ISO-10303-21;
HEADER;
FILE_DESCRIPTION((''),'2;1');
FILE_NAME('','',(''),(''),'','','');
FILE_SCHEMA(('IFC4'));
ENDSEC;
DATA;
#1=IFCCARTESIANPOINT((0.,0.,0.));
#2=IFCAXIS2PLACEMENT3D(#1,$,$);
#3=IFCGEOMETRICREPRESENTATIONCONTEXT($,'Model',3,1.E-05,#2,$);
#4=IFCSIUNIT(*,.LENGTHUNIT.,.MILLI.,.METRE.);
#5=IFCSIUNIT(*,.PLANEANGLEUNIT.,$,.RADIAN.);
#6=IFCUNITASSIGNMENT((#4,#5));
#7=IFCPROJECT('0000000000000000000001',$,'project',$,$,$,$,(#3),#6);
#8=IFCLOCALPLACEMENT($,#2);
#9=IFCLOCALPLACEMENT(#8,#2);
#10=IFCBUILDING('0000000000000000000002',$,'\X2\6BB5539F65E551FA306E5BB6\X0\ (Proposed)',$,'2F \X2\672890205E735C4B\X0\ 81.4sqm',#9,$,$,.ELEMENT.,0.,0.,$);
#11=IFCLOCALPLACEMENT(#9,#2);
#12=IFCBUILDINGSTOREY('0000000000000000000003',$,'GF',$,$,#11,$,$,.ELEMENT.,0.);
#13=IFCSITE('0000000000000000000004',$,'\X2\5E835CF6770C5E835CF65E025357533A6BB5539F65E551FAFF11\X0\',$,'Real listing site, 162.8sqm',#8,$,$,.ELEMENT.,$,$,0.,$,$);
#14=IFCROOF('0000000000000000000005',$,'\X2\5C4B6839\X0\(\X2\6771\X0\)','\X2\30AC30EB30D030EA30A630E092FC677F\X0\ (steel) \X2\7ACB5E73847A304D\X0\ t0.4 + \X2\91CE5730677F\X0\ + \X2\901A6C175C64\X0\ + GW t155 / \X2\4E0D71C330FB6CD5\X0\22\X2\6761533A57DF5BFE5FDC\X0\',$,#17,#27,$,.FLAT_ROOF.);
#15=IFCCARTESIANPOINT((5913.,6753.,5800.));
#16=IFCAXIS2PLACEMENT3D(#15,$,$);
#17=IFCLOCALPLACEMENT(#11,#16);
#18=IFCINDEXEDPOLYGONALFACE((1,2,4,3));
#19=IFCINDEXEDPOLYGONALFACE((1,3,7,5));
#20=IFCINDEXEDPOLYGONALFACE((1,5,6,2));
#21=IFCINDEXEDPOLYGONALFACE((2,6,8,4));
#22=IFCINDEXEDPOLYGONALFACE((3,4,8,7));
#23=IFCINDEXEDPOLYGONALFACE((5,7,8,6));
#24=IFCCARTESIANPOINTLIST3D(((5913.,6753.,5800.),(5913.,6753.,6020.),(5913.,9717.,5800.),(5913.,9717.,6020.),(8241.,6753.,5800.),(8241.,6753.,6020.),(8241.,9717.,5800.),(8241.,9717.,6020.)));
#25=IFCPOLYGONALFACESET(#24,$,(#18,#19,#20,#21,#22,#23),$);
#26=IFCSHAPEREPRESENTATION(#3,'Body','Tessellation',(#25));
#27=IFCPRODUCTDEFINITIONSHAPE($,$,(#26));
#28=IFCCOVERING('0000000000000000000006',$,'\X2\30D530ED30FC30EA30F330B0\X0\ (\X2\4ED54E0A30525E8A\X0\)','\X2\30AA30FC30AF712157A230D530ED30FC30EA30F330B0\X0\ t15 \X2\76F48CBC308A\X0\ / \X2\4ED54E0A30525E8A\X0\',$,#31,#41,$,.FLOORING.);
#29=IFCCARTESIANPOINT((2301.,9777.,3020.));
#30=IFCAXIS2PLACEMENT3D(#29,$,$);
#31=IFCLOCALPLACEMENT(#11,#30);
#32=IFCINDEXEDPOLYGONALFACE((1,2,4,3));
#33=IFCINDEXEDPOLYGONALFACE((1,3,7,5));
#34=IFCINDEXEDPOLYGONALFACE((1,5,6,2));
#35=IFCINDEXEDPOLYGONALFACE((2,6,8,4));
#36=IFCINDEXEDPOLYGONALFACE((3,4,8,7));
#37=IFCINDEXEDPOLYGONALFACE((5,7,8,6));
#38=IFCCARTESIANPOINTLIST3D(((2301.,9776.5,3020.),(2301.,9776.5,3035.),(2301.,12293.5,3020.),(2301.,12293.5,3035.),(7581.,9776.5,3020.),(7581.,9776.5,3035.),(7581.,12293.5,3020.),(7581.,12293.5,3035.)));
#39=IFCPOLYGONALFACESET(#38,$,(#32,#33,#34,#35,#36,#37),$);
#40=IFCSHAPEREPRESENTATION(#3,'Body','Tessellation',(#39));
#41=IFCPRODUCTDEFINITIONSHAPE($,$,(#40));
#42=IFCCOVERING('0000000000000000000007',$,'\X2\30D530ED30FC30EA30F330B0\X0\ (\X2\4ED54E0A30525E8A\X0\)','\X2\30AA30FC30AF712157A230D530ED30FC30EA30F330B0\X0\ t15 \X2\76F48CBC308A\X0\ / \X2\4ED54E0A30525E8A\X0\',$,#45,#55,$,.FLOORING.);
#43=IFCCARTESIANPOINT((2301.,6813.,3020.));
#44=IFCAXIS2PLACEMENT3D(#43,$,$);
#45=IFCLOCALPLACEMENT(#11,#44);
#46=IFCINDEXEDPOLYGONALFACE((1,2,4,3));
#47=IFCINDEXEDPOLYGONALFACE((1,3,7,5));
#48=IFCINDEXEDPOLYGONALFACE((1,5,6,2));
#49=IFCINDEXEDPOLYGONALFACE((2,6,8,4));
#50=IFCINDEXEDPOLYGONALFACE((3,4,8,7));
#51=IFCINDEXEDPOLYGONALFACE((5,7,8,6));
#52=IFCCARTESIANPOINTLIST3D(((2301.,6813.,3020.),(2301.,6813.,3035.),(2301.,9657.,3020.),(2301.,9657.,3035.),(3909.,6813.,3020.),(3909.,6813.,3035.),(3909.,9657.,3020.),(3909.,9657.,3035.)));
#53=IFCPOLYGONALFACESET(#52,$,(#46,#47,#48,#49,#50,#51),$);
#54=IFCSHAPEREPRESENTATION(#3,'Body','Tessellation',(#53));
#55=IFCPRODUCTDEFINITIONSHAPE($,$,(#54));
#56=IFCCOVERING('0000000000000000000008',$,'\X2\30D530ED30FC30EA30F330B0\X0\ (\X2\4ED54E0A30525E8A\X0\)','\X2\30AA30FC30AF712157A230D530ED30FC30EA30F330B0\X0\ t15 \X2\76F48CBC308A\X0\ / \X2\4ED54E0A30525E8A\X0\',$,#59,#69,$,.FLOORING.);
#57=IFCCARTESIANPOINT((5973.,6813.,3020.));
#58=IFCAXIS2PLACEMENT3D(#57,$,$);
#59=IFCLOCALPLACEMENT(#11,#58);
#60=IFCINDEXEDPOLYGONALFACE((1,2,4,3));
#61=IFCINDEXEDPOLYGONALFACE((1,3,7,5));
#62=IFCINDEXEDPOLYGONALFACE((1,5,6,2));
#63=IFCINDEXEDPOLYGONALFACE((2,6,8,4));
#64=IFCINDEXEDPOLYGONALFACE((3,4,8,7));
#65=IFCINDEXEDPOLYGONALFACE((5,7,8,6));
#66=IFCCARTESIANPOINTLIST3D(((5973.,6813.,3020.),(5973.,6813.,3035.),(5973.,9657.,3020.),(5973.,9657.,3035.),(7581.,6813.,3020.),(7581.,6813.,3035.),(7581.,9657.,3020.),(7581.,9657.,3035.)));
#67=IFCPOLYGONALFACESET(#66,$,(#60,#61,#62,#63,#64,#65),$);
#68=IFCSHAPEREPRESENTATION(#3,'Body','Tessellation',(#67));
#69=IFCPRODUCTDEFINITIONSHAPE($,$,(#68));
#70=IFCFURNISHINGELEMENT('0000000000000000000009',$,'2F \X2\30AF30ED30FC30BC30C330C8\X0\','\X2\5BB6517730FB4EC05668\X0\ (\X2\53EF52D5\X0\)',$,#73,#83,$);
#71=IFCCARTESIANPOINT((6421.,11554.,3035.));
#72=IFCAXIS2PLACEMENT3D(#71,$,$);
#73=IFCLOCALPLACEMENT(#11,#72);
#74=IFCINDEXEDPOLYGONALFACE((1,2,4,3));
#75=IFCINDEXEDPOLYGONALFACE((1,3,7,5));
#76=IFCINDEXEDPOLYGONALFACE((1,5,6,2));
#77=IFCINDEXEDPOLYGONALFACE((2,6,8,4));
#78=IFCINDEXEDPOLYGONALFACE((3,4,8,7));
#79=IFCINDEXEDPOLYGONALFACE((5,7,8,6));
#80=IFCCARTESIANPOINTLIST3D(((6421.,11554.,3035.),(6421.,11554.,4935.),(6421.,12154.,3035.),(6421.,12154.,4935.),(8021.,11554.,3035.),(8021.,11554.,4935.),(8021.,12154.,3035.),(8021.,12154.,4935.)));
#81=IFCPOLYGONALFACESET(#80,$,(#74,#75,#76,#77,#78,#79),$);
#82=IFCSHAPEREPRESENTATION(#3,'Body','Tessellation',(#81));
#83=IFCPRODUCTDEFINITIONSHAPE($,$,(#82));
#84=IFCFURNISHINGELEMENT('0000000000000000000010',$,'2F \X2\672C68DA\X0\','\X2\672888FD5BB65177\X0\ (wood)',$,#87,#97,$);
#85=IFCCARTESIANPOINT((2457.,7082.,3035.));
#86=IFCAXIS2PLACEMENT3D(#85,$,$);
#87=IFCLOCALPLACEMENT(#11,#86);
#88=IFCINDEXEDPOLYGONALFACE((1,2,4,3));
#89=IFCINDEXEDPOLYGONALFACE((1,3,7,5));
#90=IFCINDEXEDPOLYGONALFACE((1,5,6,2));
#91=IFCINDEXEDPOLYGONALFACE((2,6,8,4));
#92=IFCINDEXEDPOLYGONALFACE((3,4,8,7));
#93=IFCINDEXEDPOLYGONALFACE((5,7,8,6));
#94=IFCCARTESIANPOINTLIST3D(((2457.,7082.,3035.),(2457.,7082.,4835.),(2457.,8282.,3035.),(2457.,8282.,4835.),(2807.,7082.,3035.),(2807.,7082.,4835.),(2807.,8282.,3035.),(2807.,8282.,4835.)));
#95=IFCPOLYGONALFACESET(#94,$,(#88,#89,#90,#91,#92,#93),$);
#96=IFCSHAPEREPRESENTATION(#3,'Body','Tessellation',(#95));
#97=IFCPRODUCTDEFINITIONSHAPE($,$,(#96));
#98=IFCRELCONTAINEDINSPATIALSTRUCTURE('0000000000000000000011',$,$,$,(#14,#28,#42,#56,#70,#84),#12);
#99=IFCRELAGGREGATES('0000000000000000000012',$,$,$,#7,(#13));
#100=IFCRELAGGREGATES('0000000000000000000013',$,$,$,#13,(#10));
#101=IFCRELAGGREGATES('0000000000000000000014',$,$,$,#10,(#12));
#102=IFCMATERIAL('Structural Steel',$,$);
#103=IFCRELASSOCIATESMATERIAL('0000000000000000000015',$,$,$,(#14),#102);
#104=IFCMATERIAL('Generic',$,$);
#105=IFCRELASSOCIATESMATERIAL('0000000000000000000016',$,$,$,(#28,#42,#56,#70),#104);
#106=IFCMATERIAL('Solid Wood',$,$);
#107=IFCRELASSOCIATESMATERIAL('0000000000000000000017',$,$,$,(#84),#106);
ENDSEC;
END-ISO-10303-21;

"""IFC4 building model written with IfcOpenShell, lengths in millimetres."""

from ifc_helpers import new_model, si_unit, frame, frame_2d, origin, place, context, project, spatial, rectangle, extrude, material, element, save


model = new_model("IFC4")

# Units and contexts
model_context = context("Model", 3, precision=1e-05, world=origin())
ifc_project = project(units=[si_unit("LENGTHUNIT", "METRE", prefix="MILLI"), si_unit("PLANEANGLEUNIT", "RADIAN")], contexts=[model_context])

# Site, building, storey
site_placement = place(None, origin())
site = spatial("IfcSite", under=ifc_project, at=site_placement, Name="広島県広島市南区段原日出１", ObjectType="Real listing site, 162.8sqm", CompositionType="ELEMENT", RefElevation=0.0)
building_placement = place(site_placement, origin())
building = spatial("IfcBuilding", under=site, at=building_placement, Name="段原日出の家 (Proposed)", ObjectType="2F 木造平屋 81.4sqm", CompositionType="ELEMENT", ElevationOfRefHeight=0.0, ElevationOfTerrain=0.0)
storey_placement = place(building_placement, origin())
storey = spatial("IfcBuildingStorey", under=building, at=storey_placement, Name="GF", CompositionType="ELEMENT", Elevation=0.0)

# Shared definitions
ifc_material_1 = material(Name="Solid Wood")

# Roof
ifc_material_2 = material(Name="Structural Steel")
roof_1_placement = place(storey_placement, frame((5913.0, 6753.0, 5800.0)))
element("IfcRoof", 1, at=roof_1_placement, inside=storey, material=ifc_material_2, Name="屋根(東)", Description="ガルバリウム鋼板 (steel) 立平葺き t0.4 + 野地板 + 通気層 + GW t155 / 不燃・法22条区域対応", PredefinedType="FLAT_ROOF", context=model_context, shape_type="SweptSolid", body=[
    extrude(rectangle(XDim=2328.0, YDim=2964.0, at=frame_2d((1164.0, 1482.0))), frame((5913.0, 6753.0, 5800.0)), (0.0, 0.0, 1.0), 220.0),
])

# Coverings
ifc_material_3 = material(Name="Generic")
covering_1_placement = place(storey_placement, frame((2301.0, 9777.0, 3020.0)))
element("IfcCovering", 2, at=covering_1_placement, inside=storey, material=ifc_material_3, Name="フローリング (仕上げ床)", Description="オーク無垢フローリング t15 直貼り / 仕上げ床", PredefinedType="FLOORING", context=model_context, shape_type="SweptSolid", body=[
    extrude(rectangle(XDim=5280.0, YDim=2517.0, at=frame_2d((2640.0, 1258.0))), frame((2301.0, 9777.0, 3020.0)), (0.0, 0.0, 1.0), 15.0),
])
covering_2_placement = place(storey_placement, frame((2301.0, 6813.0, 3020.0)))
element("IfcCovering", 3, at=covering_2_placement, inside=storey, material=ifc_material_3, Name="フローリング (仕上げ床)", Description="オーク無垢フローリング t15 直貼り / 仕上げ床", PredefinedType="FLOORING", context=model_context, shape_type="SweptSolid", body=[
    extrude(rectangle(XDim=1608.0, YDim=2844.0, at=frame_2d((804.0, 1422.0))), frame((2301.0, 6813.0, 3020.0)), (0.0, 0.0, 1.0), 15.0),
])
covering_3_placement = place(storey_placement, frame((5973.0, 6813.0, 3020.0)))
element("IfcCovering", 4, at=covering_3_placement, inside=storey, material=ifc_material_3, Name="フローリング (仕上げ床)", Description="オーク無垢フローリング t15 直貼り / 仕上げ床", PredefinedType="FLOORING", context=model_context, shape_type="SweptSolid", body=[
    extrude(rectangle(XDim=1608.0, YDim=2844.0, at=frame_2d((804.0, 1422.0))), frame((5973.0, 6813.0, 3020.0)), (0.0, 0.0, 1.0), 15.0),
])

# Furnishing elements
furnishing_1_placement = place(storey_placement, frame((6421.0, 11554.0, 3035.0)))
element("IfcFurnishingElement", 5, at=furnishing_1_placement, inside=storey, material=ifc_material_3, Name="2F クローゼット", Description="家具・什器 (可動)", context=model_context, shape_type="SweptSolid", body=[
    extrude(rectangle(XDim=1600.0, YDim=600.0, at=frame_2d((800.0, 300.0))), frame((6421.0, 11554.0, 3035.0)), (0.0, 0.0, 1.0), 1900.0),
])
furnishing_2_placement = place(storey_placement, frame((2457.0, 7082.0, 3035.0)))
element("IfcFurnishingElement", 6, at=furnishing_2_placement, inside=storey, material=ifc_material_1, Name="2F 本棚", Description="木製家具 (wood)", context=model_context, shape_type="SweptSolid", body=[
    extrude(rectangle(XDim=350.0, YDim=1200.0, at=frame_2d((175.0, 600.0))), frame((2457.0, 7082.0, 3035.0)), (0.0, 0.0, 1.0), 1800.0),
])

save(model, "model.ifc")
